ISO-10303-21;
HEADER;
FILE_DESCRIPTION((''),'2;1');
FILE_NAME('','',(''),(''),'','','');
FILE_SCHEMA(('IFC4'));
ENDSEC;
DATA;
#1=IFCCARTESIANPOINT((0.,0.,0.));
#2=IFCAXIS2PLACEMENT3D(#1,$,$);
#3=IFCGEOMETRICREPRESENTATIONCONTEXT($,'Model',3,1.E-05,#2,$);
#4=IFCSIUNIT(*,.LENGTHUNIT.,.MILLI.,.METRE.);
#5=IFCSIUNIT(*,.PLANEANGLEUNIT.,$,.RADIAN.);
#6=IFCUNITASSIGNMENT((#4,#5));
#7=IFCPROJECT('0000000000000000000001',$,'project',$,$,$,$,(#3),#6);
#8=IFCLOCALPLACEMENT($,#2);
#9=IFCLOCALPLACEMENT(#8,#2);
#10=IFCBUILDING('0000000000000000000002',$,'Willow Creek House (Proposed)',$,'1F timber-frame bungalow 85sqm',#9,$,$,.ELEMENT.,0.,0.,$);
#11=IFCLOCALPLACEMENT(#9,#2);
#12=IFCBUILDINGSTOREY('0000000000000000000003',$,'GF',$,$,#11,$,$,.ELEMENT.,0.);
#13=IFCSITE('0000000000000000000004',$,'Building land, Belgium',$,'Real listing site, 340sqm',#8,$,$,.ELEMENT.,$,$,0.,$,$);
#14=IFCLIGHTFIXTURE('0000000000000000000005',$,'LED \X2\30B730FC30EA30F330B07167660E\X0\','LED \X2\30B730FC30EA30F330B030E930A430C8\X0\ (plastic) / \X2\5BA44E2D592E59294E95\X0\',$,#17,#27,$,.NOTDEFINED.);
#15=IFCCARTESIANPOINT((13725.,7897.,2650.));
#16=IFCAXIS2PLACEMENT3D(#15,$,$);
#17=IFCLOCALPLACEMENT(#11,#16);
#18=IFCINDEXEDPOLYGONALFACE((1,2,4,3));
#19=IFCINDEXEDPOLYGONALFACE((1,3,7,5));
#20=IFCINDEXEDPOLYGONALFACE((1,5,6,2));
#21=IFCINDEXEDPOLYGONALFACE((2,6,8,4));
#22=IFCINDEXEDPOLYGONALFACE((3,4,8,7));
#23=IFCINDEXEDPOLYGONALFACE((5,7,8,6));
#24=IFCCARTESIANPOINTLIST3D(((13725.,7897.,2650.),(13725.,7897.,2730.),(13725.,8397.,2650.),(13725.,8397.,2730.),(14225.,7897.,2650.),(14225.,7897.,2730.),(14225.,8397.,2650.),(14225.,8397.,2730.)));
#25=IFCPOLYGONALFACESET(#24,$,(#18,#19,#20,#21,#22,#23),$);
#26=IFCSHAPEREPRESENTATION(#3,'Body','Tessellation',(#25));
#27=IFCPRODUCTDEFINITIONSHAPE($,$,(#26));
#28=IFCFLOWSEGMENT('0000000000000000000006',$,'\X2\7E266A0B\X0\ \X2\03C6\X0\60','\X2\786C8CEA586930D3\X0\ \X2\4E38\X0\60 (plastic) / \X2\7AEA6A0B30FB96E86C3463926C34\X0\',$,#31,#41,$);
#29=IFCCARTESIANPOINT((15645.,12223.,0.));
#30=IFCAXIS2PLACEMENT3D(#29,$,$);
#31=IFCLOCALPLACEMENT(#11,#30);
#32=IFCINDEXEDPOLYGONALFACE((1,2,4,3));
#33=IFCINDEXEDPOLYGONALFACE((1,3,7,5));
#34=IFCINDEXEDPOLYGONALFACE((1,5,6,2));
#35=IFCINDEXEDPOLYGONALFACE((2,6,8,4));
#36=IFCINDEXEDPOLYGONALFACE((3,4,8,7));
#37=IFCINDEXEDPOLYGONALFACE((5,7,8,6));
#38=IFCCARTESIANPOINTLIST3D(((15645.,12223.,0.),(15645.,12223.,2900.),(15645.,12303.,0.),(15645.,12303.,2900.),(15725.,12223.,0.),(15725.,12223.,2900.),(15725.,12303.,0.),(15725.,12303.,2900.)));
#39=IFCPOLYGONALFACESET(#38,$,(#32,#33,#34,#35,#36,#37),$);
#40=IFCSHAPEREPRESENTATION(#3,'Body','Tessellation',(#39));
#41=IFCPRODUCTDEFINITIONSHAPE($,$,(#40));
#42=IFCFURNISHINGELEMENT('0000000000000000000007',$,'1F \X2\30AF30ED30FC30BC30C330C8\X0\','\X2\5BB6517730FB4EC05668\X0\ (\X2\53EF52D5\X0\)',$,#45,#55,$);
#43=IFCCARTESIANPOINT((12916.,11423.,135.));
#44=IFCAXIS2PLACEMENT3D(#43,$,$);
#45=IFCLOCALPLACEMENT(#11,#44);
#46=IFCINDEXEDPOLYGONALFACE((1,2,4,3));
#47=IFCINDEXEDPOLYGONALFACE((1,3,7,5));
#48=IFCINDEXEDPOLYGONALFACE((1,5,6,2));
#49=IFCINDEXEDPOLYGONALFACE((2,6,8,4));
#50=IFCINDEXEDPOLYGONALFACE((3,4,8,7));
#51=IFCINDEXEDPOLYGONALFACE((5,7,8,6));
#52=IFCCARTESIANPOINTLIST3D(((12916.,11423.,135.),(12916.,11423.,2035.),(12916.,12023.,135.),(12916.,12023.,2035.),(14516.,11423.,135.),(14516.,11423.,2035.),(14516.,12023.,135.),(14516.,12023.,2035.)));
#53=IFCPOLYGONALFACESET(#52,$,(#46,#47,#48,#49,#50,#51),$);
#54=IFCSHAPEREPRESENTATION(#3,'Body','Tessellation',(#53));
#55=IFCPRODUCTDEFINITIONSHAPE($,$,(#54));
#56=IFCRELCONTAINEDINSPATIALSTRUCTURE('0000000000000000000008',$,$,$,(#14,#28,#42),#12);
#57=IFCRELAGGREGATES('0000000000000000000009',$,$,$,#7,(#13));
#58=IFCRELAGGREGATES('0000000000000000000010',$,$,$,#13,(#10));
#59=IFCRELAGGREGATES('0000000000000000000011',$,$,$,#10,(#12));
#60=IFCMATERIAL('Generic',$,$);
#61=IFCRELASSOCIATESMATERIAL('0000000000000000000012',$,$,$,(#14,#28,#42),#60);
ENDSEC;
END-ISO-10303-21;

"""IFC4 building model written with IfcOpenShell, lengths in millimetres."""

from ifc_helpers import new_model, si_unit, frame, frame_2d, origin, place, context, project, spatial, rectangle, extrude, material, element, save


model = new_model("IFC4")

# Units and contexts
model_context = context("Model", 3, precision=1e-05, world=origin())
ifc_project = project(units=[si_unit("LENGTHUNIT", "METRE", prefix="MILLI"), si_unit("PLANEANGLEUNIT", "RADIAN")], contexts=[model_context])

# Site, building, storey
site_placement = place(None, origin())
site = spatial("IfcSite", under=ifc_project, at=site_placement, Name="Building land, Belgium", ObjectType="Real listing site, 340sqm", CompositionType="ELEMENT", RefElevation=0.0)
building_placement = place(site_placement, origin())
building = spatial("IfcBuilding", under=site, at=building_placement, Name="Willow Creek House (Proposed)", ObjectType="1F timber-frame bungalow 85sqm", CompositionType="ELEMENT", ElevationOfRefHeight=0.0, ElevationOfTerrain=0.0)
storey_placement = place(building_placement, origin())
storey = spatial("IfcBuildingStorey", under=building, at=storey_placement, Name="GF", CompositionType="ELEMENT", Elevation=0.0)

# Shared definitions
ifc_material_1 = material(Name="Generic")

# Light fixture
light_fixture_1_placement = place(storey_placement, frame((13725.0, 7897.0, 2650.0)))
element("IfcLightFixture", 1, at=light_fixture_1_placement, inside=storey, material=ifc_material_1, Name="LED シーリング照明", Description="LED シーリングライト (plastic) / 室中央天井", PredefinedType="NOTDEFINED", context=model_context, shape_type="SweptSolid", body=[
    extrude(rectangle(XDim=500.0, YDim=500.0, at=frame_2d((250.0, 250.0))), frame((13725.0, 7897.0, 2650.0)), (0.0, 0.0, 1.0), 80.0),
])

# Flow segment
flow_segment_placement = place(storey_placement, frame((15645.0, 12223.0, 0.0)))
element("IfcFlowSegment", 2, at=flow_segment_placement, inside=storey, material=ifc_material_1, Name="縦樋 φ60", Description="硬質塩ビ 丸60 (plastic) / 竪樋・雨水排水", context=model_context, shape_type="SweptSolid", body=[
    extrude(rectangle(XDim=80.0, YDim=80.0, at=frame_2d((40.0, 40.0))), frame((15645.0, 12223.0, 0.0)), (0.0, 0.0, 1.0), 2900.0),
])

# Furnishing element
furnishing_placement = place(storey_placement, frame((12916.0, 11423.0, 135.0)))
element("IfcFurnishingElement", 3, at=furnishing_placement, inside=storey, material=ifc_material_1, Name="1F クローゼット", Description="家具・什器 (可動)", context=model_context, shape_type="SweptSolid", body=[
    extrude(rectangle(XDim=1600.0, YDim=600.0, at=frame_2d((800.0, 300.0))), frame((12916.0, 11423.0, 135.0)), (0.0, 0.0, 1.0), 1900.0),
])

save(model, "model.ifc")
